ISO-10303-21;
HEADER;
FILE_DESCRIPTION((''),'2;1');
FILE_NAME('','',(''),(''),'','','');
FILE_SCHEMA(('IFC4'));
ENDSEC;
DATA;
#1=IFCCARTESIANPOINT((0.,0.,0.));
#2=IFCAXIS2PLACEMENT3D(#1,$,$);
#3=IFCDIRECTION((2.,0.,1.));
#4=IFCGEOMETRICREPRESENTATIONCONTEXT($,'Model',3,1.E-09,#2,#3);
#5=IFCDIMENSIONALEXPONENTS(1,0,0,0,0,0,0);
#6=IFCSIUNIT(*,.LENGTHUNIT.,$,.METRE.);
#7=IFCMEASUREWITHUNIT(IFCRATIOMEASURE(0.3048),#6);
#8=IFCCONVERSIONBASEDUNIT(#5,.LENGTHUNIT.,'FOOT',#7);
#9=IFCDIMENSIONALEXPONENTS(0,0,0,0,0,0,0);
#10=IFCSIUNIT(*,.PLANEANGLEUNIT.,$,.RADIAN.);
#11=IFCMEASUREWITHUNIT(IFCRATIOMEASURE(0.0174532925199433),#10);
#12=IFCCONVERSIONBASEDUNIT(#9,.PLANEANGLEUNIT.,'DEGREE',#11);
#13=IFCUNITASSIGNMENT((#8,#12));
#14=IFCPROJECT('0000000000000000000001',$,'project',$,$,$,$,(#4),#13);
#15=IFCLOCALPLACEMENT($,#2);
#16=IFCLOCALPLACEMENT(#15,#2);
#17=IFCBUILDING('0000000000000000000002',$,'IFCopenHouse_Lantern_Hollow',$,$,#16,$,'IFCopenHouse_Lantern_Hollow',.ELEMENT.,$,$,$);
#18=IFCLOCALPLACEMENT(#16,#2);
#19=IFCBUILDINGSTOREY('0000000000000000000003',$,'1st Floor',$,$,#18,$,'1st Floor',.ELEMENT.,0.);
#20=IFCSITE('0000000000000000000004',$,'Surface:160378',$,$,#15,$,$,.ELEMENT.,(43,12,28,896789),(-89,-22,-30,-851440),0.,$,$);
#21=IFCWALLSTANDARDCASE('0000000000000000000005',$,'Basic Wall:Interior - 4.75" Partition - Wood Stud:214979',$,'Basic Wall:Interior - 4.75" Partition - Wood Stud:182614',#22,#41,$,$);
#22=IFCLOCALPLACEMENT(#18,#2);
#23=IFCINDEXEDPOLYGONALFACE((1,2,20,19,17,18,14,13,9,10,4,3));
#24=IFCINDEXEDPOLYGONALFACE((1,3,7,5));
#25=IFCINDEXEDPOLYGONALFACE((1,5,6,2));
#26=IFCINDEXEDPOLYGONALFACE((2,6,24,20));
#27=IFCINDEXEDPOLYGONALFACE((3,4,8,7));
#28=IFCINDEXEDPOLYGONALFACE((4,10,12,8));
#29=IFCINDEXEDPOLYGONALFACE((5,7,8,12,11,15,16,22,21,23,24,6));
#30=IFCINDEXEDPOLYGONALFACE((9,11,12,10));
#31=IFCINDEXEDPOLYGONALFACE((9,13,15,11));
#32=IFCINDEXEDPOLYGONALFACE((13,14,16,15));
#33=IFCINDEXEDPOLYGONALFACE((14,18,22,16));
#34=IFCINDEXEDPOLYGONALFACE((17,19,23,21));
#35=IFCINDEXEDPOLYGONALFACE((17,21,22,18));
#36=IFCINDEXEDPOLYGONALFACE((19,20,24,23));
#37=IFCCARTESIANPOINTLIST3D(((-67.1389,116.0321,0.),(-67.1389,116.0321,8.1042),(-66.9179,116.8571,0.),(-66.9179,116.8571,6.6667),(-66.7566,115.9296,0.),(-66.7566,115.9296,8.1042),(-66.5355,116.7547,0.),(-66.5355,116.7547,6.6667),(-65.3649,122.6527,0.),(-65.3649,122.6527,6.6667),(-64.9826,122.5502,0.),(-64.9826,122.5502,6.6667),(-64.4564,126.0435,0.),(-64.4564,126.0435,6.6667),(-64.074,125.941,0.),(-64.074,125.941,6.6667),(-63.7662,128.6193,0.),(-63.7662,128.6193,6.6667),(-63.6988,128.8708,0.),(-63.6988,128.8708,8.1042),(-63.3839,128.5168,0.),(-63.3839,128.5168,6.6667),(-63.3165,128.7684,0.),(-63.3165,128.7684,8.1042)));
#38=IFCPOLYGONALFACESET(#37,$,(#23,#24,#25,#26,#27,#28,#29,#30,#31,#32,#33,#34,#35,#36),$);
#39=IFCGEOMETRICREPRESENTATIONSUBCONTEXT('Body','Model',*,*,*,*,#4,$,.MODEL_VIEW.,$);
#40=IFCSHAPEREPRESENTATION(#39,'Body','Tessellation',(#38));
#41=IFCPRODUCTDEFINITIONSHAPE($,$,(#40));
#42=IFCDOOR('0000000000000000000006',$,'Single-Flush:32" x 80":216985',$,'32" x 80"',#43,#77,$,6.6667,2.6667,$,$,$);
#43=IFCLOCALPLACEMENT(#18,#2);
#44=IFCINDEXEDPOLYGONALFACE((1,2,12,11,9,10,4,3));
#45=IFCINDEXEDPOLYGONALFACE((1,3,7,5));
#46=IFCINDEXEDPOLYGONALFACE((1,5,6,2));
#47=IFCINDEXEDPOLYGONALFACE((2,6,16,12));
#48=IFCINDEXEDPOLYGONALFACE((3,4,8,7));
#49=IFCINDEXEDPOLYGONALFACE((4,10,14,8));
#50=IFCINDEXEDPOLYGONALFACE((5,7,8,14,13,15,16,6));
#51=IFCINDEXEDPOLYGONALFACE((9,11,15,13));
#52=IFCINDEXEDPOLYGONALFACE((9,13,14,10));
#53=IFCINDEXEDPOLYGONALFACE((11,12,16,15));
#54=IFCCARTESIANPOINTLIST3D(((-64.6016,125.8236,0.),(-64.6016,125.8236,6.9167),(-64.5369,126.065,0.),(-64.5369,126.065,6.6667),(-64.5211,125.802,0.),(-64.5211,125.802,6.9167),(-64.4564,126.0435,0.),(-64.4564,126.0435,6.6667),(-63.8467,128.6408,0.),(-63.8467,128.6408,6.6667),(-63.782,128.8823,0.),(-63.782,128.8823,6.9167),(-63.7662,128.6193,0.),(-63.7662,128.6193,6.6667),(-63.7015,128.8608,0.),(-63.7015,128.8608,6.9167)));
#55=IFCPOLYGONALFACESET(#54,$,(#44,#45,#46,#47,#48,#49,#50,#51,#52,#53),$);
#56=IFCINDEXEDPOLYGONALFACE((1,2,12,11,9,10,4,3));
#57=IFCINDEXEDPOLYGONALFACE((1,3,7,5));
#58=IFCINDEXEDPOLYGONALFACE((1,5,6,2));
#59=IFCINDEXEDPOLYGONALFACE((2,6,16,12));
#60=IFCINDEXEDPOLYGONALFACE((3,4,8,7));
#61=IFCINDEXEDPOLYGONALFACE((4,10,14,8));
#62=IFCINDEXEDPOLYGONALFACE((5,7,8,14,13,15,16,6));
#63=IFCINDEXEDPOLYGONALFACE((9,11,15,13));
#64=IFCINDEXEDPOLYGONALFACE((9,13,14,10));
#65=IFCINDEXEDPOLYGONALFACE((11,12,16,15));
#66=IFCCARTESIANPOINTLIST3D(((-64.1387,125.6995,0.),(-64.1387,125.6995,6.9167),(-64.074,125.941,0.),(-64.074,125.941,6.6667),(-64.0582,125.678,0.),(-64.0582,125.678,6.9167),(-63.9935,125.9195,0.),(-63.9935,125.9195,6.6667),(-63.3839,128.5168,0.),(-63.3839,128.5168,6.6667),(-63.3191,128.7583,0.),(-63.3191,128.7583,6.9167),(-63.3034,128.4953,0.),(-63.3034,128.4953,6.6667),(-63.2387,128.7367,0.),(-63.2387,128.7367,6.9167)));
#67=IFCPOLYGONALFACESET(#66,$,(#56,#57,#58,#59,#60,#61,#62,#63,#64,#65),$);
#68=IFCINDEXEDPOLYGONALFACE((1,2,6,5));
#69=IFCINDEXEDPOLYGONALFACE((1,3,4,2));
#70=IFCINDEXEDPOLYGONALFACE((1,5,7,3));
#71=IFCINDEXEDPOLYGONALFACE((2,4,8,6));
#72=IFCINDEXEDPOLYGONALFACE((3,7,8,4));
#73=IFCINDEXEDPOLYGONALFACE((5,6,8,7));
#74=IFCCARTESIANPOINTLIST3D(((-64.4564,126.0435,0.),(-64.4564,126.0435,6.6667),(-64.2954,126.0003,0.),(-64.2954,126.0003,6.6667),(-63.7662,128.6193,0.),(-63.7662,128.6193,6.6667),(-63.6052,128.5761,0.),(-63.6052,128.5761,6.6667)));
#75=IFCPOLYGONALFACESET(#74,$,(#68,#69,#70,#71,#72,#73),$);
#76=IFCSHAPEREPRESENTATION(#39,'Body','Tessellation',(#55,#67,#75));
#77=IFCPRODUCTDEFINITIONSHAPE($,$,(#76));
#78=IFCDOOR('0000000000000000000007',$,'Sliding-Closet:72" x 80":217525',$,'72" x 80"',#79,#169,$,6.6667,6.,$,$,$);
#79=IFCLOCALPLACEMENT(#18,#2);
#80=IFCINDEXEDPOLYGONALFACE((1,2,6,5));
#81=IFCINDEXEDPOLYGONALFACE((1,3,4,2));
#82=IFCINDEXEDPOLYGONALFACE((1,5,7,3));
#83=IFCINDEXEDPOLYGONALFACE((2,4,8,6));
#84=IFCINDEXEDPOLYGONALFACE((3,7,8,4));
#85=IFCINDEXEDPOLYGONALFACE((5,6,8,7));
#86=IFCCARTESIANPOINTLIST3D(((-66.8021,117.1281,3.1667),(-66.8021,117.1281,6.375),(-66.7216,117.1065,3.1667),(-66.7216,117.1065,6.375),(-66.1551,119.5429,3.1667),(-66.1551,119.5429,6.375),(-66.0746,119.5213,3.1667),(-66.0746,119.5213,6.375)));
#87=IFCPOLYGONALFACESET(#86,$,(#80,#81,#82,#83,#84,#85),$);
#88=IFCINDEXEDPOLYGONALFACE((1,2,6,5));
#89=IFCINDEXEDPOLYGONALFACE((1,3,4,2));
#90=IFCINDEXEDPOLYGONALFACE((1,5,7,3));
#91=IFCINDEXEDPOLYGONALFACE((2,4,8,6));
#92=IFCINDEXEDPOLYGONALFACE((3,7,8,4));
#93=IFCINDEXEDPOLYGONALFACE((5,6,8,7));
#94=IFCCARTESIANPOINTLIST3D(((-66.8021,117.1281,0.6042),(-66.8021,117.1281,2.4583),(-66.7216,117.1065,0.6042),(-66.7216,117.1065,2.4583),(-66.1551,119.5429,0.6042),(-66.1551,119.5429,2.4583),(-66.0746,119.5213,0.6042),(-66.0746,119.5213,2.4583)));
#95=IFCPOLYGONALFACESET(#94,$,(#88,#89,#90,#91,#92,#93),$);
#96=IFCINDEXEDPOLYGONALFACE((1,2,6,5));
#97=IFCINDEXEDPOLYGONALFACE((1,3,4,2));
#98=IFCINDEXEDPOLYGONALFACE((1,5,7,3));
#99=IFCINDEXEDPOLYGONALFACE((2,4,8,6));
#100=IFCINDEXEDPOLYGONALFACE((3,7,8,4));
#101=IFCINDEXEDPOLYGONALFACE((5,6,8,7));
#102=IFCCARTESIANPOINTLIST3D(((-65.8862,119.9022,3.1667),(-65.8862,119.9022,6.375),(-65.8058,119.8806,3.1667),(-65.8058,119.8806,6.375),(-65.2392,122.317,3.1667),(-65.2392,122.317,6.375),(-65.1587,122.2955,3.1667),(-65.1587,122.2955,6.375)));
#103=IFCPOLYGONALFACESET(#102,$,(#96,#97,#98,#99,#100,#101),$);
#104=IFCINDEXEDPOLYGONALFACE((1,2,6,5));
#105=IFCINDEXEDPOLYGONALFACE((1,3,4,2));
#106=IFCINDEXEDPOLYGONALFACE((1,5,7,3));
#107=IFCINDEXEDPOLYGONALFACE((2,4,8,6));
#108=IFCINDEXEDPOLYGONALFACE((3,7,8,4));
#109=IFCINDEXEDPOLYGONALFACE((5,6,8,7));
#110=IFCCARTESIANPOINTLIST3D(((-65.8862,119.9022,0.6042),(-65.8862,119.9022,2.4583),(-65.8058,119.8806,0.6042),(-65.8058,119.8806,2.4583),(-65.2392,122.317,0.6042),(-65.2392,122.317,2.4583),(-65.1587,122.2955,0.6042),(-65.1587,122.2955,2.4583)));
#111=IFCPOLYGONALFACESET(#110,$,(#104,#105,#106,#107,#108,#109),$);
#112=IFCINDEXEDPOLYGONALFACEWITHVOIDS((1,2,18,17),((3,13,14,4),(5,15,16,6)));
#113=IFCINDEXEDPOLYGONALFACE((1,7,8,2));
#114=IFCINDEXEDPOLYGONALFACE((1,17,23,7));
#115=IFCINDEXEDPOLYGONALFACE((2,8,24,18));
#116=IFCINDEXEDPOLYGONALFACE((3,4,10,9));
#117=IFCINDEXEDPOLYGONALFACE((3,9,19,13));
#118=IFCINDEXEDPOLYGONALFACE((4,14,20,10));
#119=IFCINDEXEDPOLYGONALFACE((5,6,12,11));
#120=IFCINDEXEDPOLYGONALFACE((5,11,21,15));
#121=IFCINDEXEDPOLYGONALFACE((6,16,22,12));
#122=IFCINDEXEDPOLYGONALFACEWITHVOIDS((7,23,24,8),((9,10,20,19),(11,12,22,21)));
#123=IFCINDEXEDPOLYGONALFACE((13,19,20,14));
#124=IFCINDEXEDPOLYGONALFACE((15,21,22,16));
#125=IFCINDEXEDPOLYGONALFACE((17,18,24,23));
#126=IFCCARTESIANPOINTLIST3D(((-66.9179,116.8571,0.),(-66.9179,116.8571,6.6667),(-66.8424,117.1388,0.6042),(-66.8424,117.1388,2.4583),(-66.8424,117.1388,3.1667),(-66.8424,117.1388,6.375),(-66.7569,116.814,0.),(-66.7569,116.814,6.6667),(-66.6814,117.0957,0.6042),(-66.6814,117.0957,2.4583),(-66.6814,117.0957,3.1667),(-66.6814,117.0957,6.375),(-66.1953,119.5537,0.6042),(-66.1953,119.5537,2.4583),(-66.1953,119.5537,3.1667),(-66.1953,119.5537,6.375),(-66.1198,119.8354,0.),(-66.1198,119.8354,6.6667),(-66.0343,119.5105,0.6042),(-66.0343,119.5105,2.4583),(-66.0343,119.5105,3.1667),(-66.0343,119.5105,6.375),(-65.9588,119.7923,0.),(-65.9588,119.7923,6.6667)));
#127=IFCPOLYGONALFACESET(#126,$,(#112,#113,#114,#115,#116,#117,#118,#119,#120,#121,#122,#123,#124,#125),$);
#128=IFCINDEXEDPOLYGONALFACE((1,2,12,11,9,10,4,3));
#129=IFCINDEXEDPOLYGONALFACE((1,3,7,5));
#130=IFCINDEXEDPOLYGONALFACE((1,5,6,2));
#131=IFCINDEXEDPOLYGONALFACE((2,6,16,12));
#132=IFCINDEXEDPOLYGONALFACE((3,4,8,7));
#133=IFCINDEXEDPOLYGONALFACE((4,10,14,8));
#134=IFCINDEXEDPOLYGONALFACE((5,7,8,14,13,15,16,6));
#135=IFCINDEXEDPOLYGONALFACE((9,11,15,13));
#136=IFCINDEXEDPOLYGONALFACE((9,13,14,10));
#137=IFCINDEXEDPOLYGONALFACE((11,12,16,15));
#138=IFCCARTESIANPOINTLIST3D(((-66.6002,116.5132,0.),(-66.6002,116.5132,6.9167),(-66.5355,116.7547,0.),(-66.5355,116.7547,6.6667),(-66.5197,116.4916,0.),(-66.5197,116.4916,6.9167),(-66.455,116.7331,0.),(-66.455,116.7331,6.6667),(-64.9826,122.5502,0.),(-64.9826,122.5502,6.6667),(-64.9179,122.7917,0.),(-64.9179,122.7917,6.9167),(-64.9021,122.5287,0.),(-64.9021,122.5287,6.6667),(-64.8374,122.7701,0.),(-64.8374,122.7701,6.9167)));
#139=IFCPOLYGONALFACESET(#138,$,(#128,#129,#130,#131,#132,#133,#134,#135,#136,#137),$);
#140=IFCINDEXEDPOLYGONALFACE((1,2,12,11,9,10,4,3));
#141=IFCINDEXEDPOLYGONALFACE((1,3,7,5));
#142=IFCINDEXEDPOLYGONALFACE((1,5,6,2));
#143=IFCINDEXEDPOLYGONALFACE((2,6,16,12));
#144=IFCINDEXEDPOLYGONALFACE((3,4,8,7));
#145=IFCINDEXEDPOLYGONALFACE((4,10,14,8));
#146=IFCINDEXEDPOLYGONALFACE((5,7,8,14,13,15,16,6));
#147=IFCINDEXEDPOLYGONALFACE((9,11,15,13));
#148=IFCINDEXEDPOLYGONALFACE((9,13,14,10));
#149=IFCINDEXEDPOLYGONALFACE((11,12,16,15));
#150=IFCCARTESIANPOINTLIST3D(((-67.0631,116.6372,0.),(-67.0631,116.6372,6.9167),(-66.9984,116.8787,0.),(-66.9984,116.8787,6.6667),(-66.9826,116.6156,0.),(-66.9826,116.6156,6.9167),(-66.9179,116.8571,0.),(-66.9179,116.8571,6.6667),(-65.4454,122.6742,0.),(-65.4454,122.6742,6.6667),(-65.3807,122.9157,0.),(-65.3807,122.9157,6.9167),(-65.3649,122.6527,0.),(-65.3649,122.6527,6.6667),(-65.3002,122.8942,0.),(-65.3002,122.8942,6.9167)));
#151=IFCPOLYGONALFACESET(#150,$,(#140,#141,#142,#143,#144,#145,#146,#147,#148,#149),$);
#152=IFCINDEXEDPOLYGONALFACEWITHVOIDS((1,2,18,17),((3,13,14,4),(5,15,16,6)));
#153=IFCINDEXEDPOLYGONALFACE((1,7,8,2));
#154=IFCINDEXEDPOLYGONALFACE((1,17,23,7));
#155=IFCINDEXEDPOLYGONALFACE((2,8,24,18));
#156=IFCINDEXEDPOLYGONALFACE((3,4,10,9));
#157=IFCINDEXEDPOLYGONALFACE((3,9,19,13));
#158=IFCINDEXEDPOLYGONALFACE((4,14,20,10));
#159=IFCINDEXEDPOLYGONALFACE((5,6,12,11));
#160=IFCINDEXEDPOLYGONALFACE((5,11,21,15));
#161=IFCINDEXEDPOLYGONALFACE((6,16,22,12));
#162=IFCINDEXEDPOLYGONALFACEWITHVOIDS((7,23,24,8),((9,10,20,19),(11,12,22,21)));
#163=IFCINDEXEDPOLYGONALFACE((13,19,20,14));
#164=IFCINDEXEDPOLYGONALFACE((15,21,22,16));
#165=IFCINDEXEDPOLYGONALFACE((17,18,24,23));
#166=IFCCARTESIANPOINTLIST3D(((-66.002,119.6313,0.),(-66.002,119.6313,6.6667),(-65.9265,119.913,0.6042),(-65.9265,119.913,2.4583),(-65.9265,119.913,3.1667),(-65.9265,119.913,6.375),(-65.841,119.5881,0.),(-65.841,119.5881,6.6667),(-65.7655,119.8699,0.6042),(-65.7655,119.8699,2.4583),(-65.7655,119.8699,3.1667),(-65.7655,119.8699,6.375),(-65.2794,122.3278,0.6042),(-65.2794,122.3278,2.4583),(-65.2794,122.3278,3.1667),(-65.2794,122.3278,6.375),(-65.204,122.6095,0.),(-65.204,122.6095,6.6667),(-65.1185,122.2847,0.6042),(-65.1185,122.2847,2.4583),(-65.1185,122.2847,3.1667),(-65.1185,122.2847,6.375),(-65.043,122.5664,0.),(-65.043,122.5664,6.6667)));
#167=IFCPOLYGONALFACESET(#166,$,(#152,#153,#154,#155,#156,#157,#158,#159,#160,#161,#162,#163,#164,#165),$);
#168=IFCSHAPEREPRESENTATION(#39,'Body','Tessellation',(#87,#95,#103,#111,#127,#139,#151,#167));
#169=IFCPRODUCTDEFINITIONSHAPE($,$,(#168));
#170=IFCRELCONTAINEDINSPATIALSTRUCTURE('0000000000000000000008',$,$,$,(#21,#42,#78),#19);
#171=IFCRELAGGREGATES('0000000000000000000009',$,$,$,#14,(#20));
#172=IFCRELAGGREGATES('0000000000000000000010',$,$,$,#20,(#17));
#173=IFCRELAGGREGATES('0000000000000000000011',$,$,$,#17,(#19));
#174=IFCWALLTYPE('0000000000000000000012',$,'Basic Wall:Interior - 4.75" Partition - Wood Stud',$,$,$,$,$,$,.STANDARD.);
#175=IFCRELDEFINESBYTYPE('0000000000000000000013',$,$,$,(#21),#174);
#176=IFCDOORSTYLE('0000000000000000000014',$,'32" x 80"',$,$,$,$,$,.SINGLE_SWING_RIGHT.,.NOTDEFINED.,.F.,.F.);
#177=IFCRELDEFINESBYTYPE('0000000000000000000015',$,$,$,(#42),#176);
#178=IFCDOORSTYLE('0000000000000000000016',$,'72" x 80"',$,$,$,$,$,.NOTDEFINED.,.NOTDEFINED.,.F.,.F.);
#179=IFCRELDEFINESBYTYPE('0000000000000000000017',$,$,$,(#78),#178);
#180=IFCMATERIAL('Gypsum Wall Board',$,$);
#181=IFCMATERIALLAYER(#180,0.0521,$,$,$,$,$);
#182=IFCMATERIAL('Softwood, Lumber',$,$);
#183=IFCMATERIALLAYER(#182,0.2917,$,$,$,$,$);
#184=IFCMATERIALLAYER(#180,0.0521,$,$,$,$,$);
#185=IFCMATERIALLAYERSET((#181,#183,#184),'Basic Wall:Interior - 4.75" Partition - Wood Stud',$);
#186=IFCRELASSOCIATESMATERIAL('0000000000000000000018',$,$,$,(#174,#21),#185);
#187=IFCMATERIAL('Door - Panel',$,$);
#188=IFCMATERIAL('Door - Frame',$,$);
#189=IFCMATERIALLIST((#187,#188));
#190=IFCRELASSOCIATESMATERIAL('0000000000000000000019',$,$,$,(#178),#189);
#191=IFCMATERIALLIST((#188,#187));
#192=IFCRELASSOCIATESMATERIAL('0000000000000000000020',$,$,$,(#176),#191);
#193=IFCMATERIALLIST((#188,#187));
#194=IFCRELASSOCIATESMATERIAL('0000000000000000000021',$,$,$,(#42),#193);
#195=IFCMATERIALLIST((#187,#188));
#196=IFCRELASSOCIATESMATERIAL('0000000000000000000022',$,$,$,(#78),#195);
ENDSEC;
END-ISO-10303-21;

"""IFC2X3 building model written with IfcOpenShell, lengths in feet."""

from ifc_helpers import new_model, entity, si_unit, converted_unit, direction, frame, frame_2d, origin, origin_2d_with_axis, place, context, subcontext, project, spatial, polyline, rectangle, outline, extrude, source, transform, mapped, material, material_list, layer, layer_set, layer_usage, type_object, type_shapes, element, fill, save


model = new_model("IFC2X3")

# Units and contexts
model_context = context("Model", 3, precision=1e-09, world=origin(), true_north=direction((2.0, 0.0, 1.0)))
body_context = subcontext(model_context, "Body", "Model", "MODEL_VIEW")
ifc_project = project(units=[converted_unit("LENGTHUNIT", "FOOT", entity("IfcRatioMeasure", 0.3048), si_unit("LENGTHUNIT", "METRE"), dimensions=[1, 0, 0, 0, 0, 0, 0]), converted_unit("PLANEANGLEUNIT", "DEGREE", entity("IfcRatioMeasure", 0.0174532925199433), si_unit("PLANEANGLEUNIT", "RADIAN"), dimensions=[0, 0, 0, 0, 0, 0, 0])], contexts=[model_context])

# Site, building, storey
site_placement = place(None, origin())
site = spatial("IfcSite", under=ifc_project, at=site_placement, Name="Surface:160378", CompositionType="ELEMENT", RefLatitude=(43, 12, 28, 896789), RefLongitude=(-89, -22, -30, -851440), RefElevation=0.0)
building_placement = place(site_placement, origin())
building = spatial("IfcBuilding", under=site, at=building_placement, Name="IFCopenHouse_Lantern_Hollow", LongName="IFCopenHouse_Lantern_Hollow", CompositionType="ELEMENT")
storey_placement = place(building_placement, origin())
storey = spatial("IfcBuildingStorey", under=building, at=storey_placement, Name="1st Floor", LongName="1st Floor", CompositionType="ELEMENT", Elevation=0.0)

# Shared definitions
ifc_material_1 = material(Name="Softwood, Lumber")
ifc_material_2 = material(Name="Gypsum Wall Board")

# Shared definitions
ifc_layer_1 = layer(ifc_material_2, 0.0521)
ifc_layer_2 = layer(ifc_material_1, 0.2917)
ifc_layer_3 = layer(ifc_material_2, 0.0521)
ifc_layer_set_1 = layer_set([ifc_layer_1, ifc_layer_2, ifc_layer_3], Name="Basic Wall:Interior - 4.75\" Partition - Wood Stud")
wall_type = type_object("IfcWallType", Name="Basic Wall:Interior - 4.75\" Partition - Wood Stud", PredefinedType="STANDARD", material=ifc_layer_set_1)
ifc_material_3 = material(Name="Door - Panel")
ifc_material_4 = material(Name="Door - Frame")
ifc_material_list_1 = material_list([ifc_material_3, ifc_material_4])
door_style_1 = type_object("IfcDoorStyle", Name="72\" x 80\"", ConstructionType="NOTDEFINED", OperationType="NOTDEFINED", ParameterTakesPrecedence=False, Sizeable=False, material=ifc_material_list_1)
shared_shape_1 = source(origin(), body_context, "Body", "SweptSolid", [
    extrude(rectangle(XDim=0.0833, YDim=2.5, at=origin_2d_with_axis()), frame((1.5417, 0.3125, 3.1667), z_axis=(0.0, 0.0, 1.0), x_axis=(0.0, 1.0, 0.0)), (0.0, 0.0, 1.0), 3.2083),
    extrude(rectangle(XDim=0.0833, YDim=2.5, at=origin_2d_with_axis()), frame((1.5417, 0.3125, 0.6042), z_axis=(0.0, 0.0, 1.0), x_axis=(0.0, 1.0, 0.0)), (0.0, 0.0, 1.0), 1.8542),
    extrude(rectangle(XDim=0.0833, YDim=2.5, at=origin_2d_with_axis()), frame((4.4583, 0.1458, 3.1667), z_axis=(0.0, 0.0, 1.0), x_axis=(0.0, -1.0, 0.0)), (0.0, 0.0, 1.0), 3.2083),
    extrude(rectangle(XDim=0.0833, YDim=2.5, at=origin_2d_with_axis()), frame((4.4583, 0.1458, 0.6042), z_axis=(0.0, 0.0, 1.0), x_axis=(0.0, -1.0, 0.0)), (0.0, 0.0, 1.0), 1.8542),
    extrude(outline(polyline([(-3.3333, -1.5417), (3.3333, -1.5417), (3.3333, 1.5417), (-3.3333, 1.5417), (-3.3333, -1.5417)]), holes=[polyline([(2.7292, 1.25), (2.7292, -1.25), (0.875, -1.25), (0.875, 1.25), (2.7292, 1.25)]), polyline([(0.1667, 1.25), (0.1667, -1.25), (-3.0417, -1.25), (-3.0417, 1.25), (0.1667, 1.25)])]), frame((1.5417, 0.2292, 3.3333), z_axis=(0.0, 1.0, 0.0), x_axis=(0.0, 0.0, -1.0)), (0.0, 0.0, 1.0), 0.1667),
    extrude(outline(polyline([(-3.3958, -3.25), (3.5208, -3.25), (3.5208, 3.25), (-3.3958, 3.25), (-3.3958, 3.0), (3.2708, 3.0), (3.2708, -3.0), (-3.3958, -3.0), (-3.3958, -3.25)])), frame((3.0, -0.0833, 3.3958), z_axis=(0.0, 1.0, 0.0), x_axis=(0.0, 0.0, 1.0)), (0.0, 0.0, 1.0), 0.0833),
    extrude(outline(polyline([(-3.25, -3.3958), (-3.0, -3.3958), (-3.0, 3.2708), (3.0, 3.2708), (3.0, -3.3958), (3.25, -3.3958), (3.25, 3.5208), (-3.25, 3.5208), (-3.25, -3.3958)])), frame((3.0, 0.3958, 3.3958), z_axis=(0.0, 1.0, 0.0), x_axis=(-1.0, 0.0, 0.0)), (0.0, 0.0, 1.0), 0.0833),
    extrude(outline(polyline([(-1.5417, -3.3333), (1.5417, -3.3333), (1.5417, 3.3333), (-1.5417, 3.3333), (-1.5417, -3.3333)]), holes=[polyline([(1.25, 0.1667), (1.25, -3.0417), (-1.25, -3.0417), (-1.25, 0.1667), (1.25, 0.1667)]), polyline([(1.25, 2.7292), (1.25, 0.875), (-1.25, 0.875), (-1.25, 2.7292), (1.25, 2.7292)])]), frame((4.4583, 0.0625, 3.3333), z_axis=(0.0, 1.0, 0.0), x_axis=(1.0, 0.0, 0.0)), (0.0, 0.0, 1.0), 0.1667),
])
type_shapes(door_style_1, [shared_shape_1])

# Wall, openings, doors
ifc_layer_usage_1 = layer_usage(ifc_layer_set_1, "AXIS2", "NEGATIVE", 0.1979)
wall_1_placement = place(storey_placement, frame((-66.9478, 115.9808, 0.0), z_axis=(0.0, 0.0, 1.0), x_axis=(0.258819, 0.965926, 0.0)))
wall_1 = element("IfcWallStandardCase", 1, at=wall_1_placement, inside=storey, type_object=wall_type, material=ifc_layer_usage_1, Name="Basic Wall:Interior - 4.75\" Partition - Wood Stud:214979", ObjectType="Basic Wall:Interior - 4.75\" Partition - Wood Stud:182614", context=body_context, shape_type="SweptSolid", body=[
    extrude(rectangle(XDim=13.2917, YDim=0.3958, at=frame_2d((6.6458, 0.0), x_axis=(-1.0, 0.0))), origin(), (0.0, 0.0, 1.0), 8.1042),
])
opening_1_placement = place(wall_1_placement, frame((10.3646, -0.1979, 0.0)))
opening_1 = element("IfcOpeningElement", 2, at=opening_1_placement, cuts=wall_1, ObjectType="Opening", context=body_context, shape_type="SweptSolid", body=[
    extrude(rectangle(XDim=2.6667, YDim=6.6667, at=frame_2d((3.3333, 1.3333), x_axis=(0.0, 1.0))), frame((0.0, 0.0, 0.0), z_axis=(0.0, 1.0, 0.0), x_axis=(0.0, 0.0, 1.0)), (0.0, 0.0, 1.0), 0.3958),
])
opening_2_placement = place(wall_1_placement, frame((0.8542, -0.1979, 0.0)))
opening_2 = element("IfcOpeningElement", 3, at=opening_2_placement, cuts=wall_1, ObjectType="Opening", context=body_context, shape_type="SweptSolid", body=[
    extrude(rectangle(XDim=6.6667, YDim=6.0, at=frame_2d((3.3333, 3.0), x_axis=(-1.0, 0.0))), frame((0.0, 0.0, 0.0), z_axis=(0.0, 1.0, 0.0), x_axis=(0.0, 0.0, 1.0)), (0.0, 0.0, 1.0), 0.3958),
])
ifc_material_list_2 = material_list([ifc_material_4, ifc_material_3])
ifc_material_list_3 = material_list([ifc_material_4, ifc_material_3])
door_style_2 = type_object("IfcDoorStyle", Name="32\" x 80\"", ConstructionType="NOTDEFINED", OperationType="SINGLE_SWING_RIGHT", ParameterTakesPrecedence=False, Sizeable=False, material=ifc_material_list_3)
shared_shape_2 = source(origin(), body_context, "Body", "SweptSolid", [
    extrude(outline(polyline([(-1.5833, -3.5208), (1.5833, -3.5208), (1.5833, 3.3958), (1.3333, 3.3958), (1.3333, -3.2708), (-1.3333, -3.2708), (-1.3333, 3.3958), (-1.5833, 3.3958), (-1.5833, -3.5208)])), frame((1.3333, 0.3958, 3.3958), z_axis=(0.0, 1.0, 0.0), x_axis=(1.0, 0.0, 0.0)), (0.0, 0.0, 1.0), 0.0833),
    extrude(outline(polyline([(-3.5208, -1.5833), (3.3958, -1.5833), (3.3958, -1.3333), (-3.2708, -1.3333), (-3.2708, 1.3333), (3.3958, 1.3333), (3.3958, 1.5833), (-3.5208, 1.5833), (-3.5208, -1.5833)])), frame((1.3333, -0.0833, 3.3958), z_axis=(0.0, 1.0, 0.0), x_axis=(0.0, 0.0, -1.0)), (0.0, 0.0, 1.0), 0.0833),
    extrude(rectangle(XDim=0.1667, YDim=2.6667, at=frame_2d((0.0, 0.0), x_axis=(1.0, 0.0))), frame((1.3333, 0.3125, 0.0), z_axis=(0.0, 0.0, 1.0), x_axis=(0.0, 1.0, 0.0)), (0.0, 0.0, 1.0), 6.6667),
])
type_shapes(door_style_2, [shared_shape_2])
door_1_placement = place(opening_1_placement, origin())
door_1 = element("IfcDoor", 4, at=door_1_placement, inside=storey, type_object=door_style_2, material=ifc_material_list_2, Name="Single-Flush:32\" x 80\":216985", ObjectType="32\" x 80\"", OverallHeight=6.6667, OverallWidth=2.6667, context=body_context, shape_type="MappedRepresentation", body=[
    mapped(shared_shape_2, transform((0.0, 0.0, 0.0), scale=1.0)),
])
fill(opening_1, door_1)
ifc_material_list_4 = material_list([ifc_material_3, ifc_material_4])
door_2_placement = place(opening_2_placement, origin())
door_2 = element("IfcDoor", 5, at=door_2_placement, inside=storey, type_object=door_style_1, material=ifc_material_list_4, Name="Sliding-Closet:72\" x 80\":217525", ObjectType="72\" x 80\"", OverallHeight=6.6667, OverallWidth=6.0, context=body_context, shape_type="MappedRepresentation", body=[
    mapped(shared_shape_1, transform((0.0, 0.0, 0.0), scale=1.0)),
])
fill(opening_2, door_2)

save(model, "model.ifc")
